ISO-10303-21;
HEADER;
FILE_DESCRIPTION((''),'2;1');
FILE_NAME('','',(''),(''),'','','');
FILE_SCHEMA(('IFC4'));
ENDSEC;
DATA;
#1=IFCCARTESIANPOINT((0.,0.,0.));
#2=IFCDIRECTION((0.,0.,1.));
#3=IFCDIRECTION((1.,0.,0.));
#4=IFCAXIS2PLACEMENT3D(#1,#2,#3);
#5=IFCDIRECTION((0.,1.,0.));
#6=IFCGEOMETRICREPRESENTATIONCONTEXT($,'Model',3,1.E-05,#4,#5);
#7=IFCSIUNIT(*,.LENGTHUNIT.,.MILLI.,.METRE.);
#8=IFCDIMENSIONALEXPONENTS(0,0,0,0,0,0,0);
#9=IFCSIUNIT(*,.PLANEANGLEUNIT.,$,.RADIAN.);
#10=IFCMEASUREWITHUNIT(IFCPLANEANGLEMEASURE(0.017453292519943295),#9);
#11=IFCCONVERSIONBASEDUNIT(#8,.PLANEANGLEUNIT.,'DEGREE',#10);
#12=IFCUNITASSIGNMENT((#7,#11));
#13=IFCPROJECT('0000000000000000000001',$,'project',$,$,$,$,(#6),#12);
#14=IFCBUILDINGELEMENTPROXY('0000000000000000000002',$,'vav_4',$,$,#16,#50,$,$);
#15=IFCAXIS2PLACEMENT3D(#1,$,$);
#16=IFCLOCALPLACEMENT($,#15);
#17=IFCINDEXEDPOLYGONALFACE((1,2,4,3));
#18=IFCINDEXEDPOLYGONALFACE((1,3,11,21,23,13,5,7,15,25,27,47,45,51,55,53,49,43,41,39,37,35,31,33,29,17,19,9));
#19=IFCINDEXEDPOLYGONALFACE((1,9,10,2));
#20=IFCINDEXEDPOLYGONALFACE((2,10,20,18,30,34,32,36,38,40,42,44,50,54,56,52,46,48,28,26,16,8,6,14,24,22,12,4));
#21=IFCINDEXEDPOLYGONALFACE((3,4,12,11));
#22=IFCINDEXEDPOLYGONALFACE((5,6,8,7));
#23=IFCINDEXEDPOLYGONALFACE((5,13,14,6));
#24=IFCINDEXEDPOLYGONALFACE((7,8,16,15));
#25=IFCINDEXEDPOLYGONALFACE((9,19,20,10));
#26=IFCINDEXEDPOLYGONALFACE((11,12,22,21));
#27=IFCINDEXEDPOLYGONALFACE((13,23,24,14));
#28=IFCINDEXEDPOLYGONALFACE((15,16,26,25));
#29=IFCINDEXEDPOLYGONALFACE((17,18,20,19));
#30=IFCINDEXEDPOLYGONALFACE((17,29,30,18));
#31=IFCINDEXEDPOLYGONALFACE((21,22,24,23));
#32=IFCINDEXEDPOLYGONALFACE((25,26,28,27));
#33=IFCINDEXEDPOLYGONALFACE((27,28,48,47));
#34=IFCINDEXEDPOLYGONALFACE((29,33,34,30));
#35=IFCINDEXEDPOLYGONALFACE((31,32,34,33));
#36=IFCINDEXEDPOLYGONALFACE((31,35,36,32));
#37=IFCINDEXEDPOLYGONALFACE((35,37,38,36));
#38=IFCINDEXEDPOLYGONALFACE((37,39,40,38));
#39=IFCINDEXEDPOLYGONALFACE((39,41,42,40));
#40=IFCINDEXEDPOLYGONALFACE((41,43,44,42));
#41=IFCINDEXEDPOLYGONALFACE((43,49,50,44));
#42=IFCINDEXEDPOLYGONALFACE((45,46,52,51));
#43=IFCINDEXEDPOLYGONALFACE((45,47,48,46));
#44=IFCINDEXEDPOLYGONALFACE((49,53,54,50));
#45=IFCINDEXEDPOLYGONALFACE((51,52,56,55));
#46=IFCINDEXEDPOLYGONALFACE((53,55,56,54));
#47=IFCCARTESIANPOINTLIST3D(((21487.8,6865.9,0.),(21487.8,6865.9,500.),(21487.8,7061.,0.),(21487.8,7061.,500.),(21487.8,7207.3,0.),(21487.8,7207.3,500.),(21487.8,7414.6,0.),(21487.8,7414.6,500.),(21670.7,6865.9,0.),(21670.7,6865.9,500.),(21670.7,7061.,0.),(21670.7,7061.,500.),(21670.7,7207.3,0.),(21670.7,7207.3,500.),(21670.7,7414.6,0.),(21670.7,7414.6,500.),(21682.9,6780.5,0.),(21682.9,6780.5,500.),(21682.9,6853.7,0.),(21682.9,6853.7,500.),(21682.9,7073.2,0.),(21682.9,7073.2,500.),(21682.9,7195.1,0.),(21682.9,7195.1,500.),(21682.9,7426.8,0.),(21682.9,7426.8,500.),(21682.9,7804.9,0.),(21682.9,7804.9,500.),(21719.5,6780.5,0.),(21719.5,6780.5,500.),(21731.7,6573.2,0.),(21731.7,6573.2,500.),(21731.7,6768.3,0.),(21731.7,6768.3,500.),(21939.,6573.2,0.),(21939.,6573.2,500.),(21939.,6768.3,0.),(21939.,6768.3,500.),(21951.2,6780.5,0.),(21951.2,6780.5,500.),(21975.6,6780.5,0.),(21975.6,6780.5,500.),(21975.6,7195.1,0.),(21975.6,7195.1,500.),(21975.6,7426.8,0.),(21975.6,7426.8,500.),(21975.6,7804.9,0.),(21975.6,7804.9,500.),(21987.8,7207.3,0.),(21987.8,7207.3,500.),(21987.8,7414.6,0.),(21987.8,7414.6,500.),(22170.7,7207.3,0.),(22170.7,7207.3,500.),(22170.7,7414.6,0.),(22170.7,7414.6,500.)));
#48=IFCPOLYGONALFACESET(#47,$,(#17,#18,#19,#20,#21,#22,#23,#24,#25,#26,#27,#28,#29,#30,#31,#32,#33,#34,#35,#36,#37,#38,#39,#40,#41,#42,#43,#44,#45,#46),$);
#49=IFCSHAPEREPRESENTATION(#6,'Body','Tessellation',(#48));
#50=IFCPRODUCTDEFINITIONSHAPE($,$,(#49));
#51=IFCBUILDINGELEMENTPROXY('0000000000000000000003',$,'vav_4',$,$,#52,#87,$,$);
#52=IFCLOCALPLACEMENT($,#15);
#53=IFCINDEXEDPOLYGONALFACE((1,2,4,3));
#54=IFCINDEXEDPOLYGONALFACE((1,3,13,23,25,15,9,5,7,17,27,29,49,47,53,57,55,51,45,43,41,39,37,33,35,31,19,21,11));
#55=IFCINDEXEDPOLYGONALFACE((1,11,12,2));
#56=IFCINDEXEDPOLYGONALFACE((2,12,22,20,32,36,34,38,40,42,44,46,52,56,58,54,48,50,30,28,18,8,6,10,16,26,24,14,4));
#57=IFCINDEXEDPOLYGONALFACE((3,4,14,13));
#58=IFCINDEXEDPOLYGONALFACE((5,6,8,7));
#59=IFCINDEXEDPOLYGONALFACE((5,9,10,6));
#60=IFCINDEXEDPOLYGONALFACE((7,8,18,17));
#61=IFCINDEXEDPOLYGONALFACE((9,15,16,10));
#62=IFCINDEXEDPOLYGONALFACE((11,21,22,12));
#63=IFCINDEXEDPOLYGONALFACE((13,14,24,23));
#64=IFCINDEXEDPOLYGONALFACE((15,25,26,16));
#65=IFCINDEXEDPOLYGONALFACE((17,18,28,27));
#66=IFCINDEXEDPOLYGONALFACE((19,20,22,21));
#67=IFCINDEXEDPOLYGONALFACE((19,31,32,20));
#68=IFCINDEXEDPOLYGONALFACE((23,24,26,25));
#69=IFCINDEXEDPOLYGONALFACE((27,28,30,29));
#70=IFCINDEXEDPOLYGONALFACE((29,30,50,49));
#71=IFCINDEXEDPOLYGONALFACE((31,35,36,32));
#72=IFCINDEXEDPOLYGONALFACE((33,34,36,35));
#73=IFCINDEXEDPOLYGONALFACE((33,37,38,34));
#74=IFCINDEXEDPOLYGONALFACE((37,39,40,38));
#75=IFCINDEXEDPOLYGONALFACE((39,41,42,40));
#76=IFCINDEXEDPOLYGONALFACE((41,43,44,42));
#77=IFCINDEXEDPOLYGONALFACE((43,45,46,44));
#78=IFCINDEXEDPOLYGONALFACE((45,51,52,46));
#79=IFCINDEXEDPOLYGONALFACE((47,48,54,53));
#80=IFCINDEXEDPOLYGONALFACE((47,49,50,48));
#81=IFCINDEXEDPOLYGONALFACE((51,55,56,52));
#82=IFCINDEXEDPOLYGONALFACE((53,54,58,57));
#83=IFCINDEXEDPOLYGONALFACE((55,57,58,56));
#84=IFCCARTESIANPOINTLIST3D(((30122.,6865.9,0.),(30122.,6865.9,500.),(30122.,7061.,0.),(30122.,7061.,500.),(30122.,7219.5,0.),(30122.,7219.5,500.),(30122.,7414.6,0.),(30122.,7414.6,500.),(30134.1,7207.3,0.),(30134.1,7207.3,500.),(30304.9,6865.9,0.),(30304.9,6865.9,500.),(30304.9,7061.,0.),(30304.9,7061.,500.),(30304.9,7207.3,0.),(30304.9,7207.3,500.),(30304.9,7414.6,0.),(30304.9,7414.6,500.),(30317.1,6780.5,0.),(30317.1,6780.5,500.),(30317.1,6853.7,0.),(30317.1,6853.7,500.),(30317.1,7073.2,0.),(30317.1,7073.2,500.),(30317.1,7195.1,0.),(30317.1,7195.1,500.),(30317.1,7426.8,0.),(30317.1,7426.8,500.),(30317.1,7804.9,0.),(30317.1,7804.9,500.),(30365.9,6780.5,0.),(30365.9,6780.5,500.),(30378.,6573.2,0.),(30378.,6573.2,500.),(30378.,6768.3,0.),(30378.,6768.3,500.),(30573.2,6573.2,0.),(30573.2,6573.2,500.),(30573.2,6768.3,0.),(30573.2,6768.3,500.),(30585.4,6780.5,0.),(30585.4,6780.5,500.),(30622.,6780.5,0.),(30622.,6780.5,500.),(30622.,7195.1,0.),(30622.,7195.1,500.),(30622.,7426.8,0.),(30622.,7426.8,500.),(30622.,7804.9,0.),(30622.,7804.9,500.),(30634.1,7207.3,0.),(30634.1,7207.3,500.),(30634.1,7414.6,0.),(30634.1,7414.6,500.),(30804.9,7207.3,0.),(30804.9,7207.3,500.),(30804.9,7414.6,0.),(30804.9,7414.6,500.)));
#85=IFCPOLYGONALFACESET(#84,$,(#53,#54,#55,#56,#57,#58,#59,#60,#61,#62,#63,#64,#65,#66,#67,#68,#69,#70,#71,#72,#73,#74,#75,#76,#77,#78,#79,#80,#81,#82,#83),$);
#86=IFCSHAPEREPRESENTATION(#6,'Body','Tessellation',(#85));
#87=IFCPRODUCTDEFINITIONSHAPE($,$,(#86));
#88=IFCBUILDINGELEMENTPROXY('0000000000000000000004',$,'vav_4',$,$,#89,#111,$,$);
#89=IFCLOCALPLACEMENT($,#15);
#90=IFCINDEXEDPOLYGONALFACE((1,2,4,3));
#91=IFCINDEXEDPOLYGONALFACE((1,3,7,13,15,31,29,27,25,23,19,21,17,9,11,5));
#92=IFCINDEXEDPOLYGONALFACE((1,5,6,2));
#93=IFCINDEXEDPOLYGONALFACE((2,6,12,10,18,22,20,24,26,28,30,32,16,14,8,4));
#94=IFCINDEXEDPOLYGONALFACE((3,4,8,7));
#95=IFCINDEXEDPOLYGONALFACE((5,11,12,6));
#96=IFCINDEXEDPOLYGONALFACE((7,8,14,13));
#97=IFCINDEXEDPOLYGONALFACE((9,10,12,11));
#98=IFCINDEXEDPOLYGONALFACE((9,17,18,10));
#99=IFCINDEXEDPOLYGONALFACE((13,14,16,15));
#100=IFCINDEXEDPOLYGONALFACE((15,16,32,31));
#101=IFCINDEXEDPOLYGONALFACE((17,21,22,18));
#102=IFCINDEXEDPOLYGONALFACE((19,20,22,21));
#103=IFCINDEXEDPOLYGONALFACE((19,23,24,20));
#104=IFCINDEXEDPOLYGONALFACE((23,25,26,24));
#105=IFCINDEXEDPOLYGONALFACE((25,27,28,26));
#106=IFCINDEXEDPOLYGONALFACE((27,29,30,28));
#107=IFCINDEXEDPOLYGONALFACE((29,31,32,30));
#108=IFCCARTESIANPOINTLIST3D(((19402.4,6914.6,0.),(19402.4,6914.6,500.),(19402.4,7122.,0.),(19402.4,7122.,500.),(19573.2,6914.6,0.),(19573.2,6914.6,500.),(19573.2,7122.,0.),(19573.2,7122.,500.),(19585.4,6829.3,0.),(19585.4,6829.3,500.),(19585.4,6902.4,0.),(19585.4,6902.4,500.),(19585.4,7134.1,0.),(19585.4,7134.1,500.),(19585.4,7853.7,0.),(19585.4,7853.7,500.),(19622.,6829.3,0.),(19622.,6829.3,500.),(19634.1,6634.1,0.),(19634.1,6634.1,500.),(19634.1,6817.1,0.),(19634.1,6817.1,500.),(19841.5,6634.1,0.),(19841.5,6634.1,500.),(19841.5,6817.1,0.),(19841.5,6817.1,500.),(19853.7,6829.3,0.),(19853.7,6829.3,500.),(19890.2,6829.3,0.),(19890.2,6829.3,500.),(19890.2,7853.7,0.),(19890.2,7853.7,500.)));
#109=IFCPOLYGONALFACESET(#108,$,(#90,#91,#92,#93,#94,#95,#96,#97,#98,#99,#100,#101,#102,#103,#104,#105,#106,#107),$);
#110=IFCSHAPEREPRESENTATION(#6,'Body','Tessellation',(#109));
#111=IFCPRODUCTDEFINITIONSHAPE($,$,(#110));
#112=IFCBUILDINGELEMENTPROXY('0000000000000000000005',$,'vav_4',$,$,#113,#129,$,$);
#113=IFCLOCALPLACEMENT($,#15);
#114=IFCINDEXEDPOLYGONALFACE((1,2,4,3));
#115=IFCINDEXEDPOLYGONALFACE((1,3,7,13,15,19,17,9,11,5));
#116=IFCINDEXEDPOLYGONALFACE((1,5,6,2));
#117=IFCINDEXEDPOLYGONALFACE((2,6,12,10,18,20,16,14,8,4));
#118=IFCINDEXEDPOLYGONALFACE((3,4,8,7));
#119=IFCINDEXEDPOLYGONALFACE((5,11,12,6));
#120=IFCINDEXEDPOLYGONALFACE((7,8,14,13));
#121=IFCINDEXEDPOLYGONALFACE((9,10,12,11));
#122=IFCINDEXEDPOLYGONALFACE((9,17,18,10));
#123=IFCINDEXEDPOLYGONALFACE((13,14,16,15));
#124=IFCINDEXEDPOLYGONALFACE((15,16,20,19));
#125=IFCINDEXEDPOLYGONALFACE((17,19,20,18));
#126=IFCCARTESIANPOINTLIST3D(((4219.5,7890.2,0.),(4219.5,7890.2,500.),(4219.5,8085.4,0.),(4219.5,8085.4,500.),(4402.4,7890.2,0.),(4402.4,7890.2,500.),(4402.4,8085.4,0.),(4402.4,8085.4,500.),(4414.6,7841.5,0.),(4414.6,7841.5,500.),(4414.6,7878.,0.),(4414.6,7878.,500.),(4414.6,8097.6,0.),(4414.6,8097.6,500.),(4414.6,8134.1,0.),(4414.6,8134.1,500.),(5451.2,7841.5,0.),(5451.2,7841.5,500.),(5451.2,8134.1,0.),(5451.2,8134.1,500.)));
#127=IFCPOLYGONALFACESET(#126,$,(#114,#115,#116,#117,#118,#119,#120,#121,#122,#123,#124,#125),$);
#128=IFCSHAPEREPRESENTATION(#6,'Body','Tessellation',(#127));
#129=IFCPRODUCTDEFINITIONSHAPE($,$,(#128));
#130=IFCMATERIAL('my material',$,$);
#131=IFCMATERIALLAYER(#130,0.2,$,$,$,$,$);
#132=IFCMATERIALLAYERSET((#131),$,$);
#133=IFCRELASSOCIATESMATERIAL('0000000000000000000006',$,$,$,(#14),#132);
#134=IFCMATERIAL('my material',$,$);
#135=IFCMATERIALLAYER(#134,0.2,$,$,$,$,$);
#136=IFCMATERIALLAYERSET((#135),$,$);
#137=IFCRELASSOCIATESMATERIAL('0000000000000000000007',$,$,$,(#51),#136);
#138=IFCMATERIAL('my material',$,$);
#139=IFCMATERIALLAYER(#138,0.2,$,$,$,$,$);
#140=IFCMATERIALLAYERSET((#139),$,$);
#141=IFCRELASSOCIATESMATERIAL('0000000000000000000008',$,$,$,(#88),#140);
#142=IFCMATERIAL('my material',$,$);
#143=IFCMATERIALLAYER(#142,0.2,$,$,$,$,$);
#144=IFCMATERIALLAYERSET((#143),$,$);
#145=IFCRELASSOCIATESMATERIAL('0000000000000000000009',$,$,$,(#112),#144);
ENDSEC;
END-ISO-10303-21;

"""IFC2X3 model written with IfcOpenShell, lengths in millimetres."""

from ifc_helpers import new_model, entity, si_unit, converted_unit, direction, origin_with_axes, place, context, project, polyline, outline, extrude, material, layer, layer_set, layer_usage, element, save


model = new_model("IFC2X3")

# Units and contexts
model_context = context("Model", 3, precision=1e-05, world=origin_with_axes(), true_north=direction((0.0, 1.0, 0.0)))
ifc_project = project(units=[si_unit("LENGTHUNIT", "METRE", prefix="MILLI"), converted_unit("PLANEANGLEUNIT", "DEGREE", entity("IfcPlaneAngleMeasure", 0.017453292519943295), si_unit("PLANEANGLEUNIT", "RADIAN"), dimensions=[0, 0, 0, 0, 0, 0, 0])], contexts=[model_context])

# Building element proxies
ifc_material_1 = material(Name="my material")
ifc_layer_1 = layer(ifc_material_1, 0.2)
ifc_layer_set_1 = layer_set([ifc_layer_1])
ifc_layer_usage_1 = layer_usage(ifc_layer_set_1, "AXIS2", "POSITIVE", -0.1)
proxy_1_placement = place(None, origin_with_axes())
element("IfcBuildingElementProxy", 1, at=proxy_1_placement, material=ifc_layer_usage_1, Name="vav_4", context=model_context, shape_type="SweptSolid", body=[
    extrude(outline(polyline([(21487.8, 6865.9), (21670.7, 6865.9), (21682.9, 6853.7), (21682.9, 6780.5), (21719.5, 6780.5), (21731.7, 6768.3), (21731.7, 6573.2), (21939.0, 6573.2), (21939.0, 6768.3), (21951.2, 6780.5), (21975.6, 6780.5), (21975.6, 7195.1), (21987.8, 7207.3), (22170.7, 7207.3), (22170.7, 7414.6), (21987.8, 7414.6), (21975.6, 7426.8), (21975.6, 7804.9), (21682.9, 7804.9), (21682.9, 7426.8), (21670.7, 7414.6), (21487.8, 7414.6), (21487.8, 7207.3), (21670.7, 7207.3), (21682.9, 7195.1), (21682.9, 7073.2), (21670.7, 7061.0), (21487.8, 7061.0), (21487.8, 6865.9)])), origin_with_axes(), (0.0, 0.0, 1.0), 500.0),
])
ifc_material_2 = material(Name="my material")
ifc_layer_2 = layer(ifc_material_2, 0.2)
ifc_layer_set_2 = layer_set([ifc_layer_2])
ifc_layer_usage_2 = layer_usage(ifc_layer_set_2, "AXIS2", "POSITIVE", -0.1)
proxy_2_placement = place(None, origin_with_axes())
element("IfcBuildingElementProxy", 2, at=proxy_2_placement, material=ifc_layer_usage_2, Name="vav_4", context=model_context, shape_type="SweptSolid", body=[
    extrude(outline(polyline([(30122.0, 6865.9), (30304.9, 6865.9), (30317.1, 6853.7), (30317.1, 6780.5), (30365.9, 6780.5), (30378.0, 6768.3), (30378.0, 6573.2), (30573.2, 6573.2), (30573.2, 6768.3), (30585.4, 6780.5), (30622.0, 6780.5), (30622.0, 7195.1), (30634.1, 7207.3), (30804.9, 7207.3), (30804.9, 7414.6), (30634.1, 7414.6), (30622.0, 7426.8), (30622.0, 7804.9), (30317.1, 7804.9), (30317.1, 7426.8), (30304.9, 7414.6), (30122.0, 7414.6), (30122.0, 7219.5), (30134.1, 7207.3), (30304.9, 7207.3), (30317.1, 7195.1), (30317.1, 7073.2), (30304.9, 7061.0), (30122.0, 7061.0), (30122.0, 6865.9)])), origin_with_axes(), (0.0, 0.0, 1.0), 500.0),
])
ifc_material_3 = material(Name="my material")
ifc_layer_3 = layer(ifc_material_3, 0.2)
ifc_layer_set_3 = layer_set([ifc_layer_3])
ifc_layer_usage_3 = layer_usage(ifc_layer_set_3, "AXIS2", "POSITIVE", -0.1)
proxy_3_placement = place(None, origin_with_axes())
element("IfcBuildingElementProxy", 3, at=proxy_3_placement, material=ifc_layer_usage_3, Name="vav_4", context=model_context, shape_type="SweptSolid", body=[
    extrude(outline(polyline([(19402.4, 6914.6), (19573.2, 6914.6), (19585.4, 6902.4), (19585.4, 6829.3), (19622.0, 6829.3), (19634.1, 6817.1), (19634.1, 6634.1), (19841.5, 6634.1), (19841.5, 6817.1), (19853.7, 6829.3), (19890.2, 6829.3), (19890.2, 7853.7), (19585.4, 7853.7), (19585.4, 7134.1), (19573.2, 7122.0), (19402.4, 7122.0), (19402.4, 6914.6)])), origin_with_axes(), (0.0, 0.0, 1.0), 500.0),
])
ifc_material_4 = material(Name="my material")
ifc_layer_4 = layer(ifc_material_4, 0.2)
ifc_layer_set_4 = layer_set([ifc_layer_4])
ifc_layer_usage_4 = layer_usage(ifc_layer_set_4, "AXIS2", "POSITIVE", -0.1)
proxy_4_placement = place(None, origin_with_axes())
element("IfcBuildingElementProxy", 4, at=proxy_4_placement, material=ifc_layer_usage_4, Name="vav_4", context=model_context, shape_type="SweptSolid", body=[
    extrude(outline(polyline([(4219.5, 7890.2), (4402.4, 7890.2), (4414.6, 7878.0), (4414.6, 7841.5), (5451.2, 7841.5), (5451.2, 8134.1), (4414.6, 8134.1), (4414.6, 8097.6), (4402.4, 8085.4), (4219.5, 8085.4), (4219.5, 7890.2)])), origin_with_axes(), (0.0, 0.0, 1.0), 500.0),
])

save(model, "model.ifc")
